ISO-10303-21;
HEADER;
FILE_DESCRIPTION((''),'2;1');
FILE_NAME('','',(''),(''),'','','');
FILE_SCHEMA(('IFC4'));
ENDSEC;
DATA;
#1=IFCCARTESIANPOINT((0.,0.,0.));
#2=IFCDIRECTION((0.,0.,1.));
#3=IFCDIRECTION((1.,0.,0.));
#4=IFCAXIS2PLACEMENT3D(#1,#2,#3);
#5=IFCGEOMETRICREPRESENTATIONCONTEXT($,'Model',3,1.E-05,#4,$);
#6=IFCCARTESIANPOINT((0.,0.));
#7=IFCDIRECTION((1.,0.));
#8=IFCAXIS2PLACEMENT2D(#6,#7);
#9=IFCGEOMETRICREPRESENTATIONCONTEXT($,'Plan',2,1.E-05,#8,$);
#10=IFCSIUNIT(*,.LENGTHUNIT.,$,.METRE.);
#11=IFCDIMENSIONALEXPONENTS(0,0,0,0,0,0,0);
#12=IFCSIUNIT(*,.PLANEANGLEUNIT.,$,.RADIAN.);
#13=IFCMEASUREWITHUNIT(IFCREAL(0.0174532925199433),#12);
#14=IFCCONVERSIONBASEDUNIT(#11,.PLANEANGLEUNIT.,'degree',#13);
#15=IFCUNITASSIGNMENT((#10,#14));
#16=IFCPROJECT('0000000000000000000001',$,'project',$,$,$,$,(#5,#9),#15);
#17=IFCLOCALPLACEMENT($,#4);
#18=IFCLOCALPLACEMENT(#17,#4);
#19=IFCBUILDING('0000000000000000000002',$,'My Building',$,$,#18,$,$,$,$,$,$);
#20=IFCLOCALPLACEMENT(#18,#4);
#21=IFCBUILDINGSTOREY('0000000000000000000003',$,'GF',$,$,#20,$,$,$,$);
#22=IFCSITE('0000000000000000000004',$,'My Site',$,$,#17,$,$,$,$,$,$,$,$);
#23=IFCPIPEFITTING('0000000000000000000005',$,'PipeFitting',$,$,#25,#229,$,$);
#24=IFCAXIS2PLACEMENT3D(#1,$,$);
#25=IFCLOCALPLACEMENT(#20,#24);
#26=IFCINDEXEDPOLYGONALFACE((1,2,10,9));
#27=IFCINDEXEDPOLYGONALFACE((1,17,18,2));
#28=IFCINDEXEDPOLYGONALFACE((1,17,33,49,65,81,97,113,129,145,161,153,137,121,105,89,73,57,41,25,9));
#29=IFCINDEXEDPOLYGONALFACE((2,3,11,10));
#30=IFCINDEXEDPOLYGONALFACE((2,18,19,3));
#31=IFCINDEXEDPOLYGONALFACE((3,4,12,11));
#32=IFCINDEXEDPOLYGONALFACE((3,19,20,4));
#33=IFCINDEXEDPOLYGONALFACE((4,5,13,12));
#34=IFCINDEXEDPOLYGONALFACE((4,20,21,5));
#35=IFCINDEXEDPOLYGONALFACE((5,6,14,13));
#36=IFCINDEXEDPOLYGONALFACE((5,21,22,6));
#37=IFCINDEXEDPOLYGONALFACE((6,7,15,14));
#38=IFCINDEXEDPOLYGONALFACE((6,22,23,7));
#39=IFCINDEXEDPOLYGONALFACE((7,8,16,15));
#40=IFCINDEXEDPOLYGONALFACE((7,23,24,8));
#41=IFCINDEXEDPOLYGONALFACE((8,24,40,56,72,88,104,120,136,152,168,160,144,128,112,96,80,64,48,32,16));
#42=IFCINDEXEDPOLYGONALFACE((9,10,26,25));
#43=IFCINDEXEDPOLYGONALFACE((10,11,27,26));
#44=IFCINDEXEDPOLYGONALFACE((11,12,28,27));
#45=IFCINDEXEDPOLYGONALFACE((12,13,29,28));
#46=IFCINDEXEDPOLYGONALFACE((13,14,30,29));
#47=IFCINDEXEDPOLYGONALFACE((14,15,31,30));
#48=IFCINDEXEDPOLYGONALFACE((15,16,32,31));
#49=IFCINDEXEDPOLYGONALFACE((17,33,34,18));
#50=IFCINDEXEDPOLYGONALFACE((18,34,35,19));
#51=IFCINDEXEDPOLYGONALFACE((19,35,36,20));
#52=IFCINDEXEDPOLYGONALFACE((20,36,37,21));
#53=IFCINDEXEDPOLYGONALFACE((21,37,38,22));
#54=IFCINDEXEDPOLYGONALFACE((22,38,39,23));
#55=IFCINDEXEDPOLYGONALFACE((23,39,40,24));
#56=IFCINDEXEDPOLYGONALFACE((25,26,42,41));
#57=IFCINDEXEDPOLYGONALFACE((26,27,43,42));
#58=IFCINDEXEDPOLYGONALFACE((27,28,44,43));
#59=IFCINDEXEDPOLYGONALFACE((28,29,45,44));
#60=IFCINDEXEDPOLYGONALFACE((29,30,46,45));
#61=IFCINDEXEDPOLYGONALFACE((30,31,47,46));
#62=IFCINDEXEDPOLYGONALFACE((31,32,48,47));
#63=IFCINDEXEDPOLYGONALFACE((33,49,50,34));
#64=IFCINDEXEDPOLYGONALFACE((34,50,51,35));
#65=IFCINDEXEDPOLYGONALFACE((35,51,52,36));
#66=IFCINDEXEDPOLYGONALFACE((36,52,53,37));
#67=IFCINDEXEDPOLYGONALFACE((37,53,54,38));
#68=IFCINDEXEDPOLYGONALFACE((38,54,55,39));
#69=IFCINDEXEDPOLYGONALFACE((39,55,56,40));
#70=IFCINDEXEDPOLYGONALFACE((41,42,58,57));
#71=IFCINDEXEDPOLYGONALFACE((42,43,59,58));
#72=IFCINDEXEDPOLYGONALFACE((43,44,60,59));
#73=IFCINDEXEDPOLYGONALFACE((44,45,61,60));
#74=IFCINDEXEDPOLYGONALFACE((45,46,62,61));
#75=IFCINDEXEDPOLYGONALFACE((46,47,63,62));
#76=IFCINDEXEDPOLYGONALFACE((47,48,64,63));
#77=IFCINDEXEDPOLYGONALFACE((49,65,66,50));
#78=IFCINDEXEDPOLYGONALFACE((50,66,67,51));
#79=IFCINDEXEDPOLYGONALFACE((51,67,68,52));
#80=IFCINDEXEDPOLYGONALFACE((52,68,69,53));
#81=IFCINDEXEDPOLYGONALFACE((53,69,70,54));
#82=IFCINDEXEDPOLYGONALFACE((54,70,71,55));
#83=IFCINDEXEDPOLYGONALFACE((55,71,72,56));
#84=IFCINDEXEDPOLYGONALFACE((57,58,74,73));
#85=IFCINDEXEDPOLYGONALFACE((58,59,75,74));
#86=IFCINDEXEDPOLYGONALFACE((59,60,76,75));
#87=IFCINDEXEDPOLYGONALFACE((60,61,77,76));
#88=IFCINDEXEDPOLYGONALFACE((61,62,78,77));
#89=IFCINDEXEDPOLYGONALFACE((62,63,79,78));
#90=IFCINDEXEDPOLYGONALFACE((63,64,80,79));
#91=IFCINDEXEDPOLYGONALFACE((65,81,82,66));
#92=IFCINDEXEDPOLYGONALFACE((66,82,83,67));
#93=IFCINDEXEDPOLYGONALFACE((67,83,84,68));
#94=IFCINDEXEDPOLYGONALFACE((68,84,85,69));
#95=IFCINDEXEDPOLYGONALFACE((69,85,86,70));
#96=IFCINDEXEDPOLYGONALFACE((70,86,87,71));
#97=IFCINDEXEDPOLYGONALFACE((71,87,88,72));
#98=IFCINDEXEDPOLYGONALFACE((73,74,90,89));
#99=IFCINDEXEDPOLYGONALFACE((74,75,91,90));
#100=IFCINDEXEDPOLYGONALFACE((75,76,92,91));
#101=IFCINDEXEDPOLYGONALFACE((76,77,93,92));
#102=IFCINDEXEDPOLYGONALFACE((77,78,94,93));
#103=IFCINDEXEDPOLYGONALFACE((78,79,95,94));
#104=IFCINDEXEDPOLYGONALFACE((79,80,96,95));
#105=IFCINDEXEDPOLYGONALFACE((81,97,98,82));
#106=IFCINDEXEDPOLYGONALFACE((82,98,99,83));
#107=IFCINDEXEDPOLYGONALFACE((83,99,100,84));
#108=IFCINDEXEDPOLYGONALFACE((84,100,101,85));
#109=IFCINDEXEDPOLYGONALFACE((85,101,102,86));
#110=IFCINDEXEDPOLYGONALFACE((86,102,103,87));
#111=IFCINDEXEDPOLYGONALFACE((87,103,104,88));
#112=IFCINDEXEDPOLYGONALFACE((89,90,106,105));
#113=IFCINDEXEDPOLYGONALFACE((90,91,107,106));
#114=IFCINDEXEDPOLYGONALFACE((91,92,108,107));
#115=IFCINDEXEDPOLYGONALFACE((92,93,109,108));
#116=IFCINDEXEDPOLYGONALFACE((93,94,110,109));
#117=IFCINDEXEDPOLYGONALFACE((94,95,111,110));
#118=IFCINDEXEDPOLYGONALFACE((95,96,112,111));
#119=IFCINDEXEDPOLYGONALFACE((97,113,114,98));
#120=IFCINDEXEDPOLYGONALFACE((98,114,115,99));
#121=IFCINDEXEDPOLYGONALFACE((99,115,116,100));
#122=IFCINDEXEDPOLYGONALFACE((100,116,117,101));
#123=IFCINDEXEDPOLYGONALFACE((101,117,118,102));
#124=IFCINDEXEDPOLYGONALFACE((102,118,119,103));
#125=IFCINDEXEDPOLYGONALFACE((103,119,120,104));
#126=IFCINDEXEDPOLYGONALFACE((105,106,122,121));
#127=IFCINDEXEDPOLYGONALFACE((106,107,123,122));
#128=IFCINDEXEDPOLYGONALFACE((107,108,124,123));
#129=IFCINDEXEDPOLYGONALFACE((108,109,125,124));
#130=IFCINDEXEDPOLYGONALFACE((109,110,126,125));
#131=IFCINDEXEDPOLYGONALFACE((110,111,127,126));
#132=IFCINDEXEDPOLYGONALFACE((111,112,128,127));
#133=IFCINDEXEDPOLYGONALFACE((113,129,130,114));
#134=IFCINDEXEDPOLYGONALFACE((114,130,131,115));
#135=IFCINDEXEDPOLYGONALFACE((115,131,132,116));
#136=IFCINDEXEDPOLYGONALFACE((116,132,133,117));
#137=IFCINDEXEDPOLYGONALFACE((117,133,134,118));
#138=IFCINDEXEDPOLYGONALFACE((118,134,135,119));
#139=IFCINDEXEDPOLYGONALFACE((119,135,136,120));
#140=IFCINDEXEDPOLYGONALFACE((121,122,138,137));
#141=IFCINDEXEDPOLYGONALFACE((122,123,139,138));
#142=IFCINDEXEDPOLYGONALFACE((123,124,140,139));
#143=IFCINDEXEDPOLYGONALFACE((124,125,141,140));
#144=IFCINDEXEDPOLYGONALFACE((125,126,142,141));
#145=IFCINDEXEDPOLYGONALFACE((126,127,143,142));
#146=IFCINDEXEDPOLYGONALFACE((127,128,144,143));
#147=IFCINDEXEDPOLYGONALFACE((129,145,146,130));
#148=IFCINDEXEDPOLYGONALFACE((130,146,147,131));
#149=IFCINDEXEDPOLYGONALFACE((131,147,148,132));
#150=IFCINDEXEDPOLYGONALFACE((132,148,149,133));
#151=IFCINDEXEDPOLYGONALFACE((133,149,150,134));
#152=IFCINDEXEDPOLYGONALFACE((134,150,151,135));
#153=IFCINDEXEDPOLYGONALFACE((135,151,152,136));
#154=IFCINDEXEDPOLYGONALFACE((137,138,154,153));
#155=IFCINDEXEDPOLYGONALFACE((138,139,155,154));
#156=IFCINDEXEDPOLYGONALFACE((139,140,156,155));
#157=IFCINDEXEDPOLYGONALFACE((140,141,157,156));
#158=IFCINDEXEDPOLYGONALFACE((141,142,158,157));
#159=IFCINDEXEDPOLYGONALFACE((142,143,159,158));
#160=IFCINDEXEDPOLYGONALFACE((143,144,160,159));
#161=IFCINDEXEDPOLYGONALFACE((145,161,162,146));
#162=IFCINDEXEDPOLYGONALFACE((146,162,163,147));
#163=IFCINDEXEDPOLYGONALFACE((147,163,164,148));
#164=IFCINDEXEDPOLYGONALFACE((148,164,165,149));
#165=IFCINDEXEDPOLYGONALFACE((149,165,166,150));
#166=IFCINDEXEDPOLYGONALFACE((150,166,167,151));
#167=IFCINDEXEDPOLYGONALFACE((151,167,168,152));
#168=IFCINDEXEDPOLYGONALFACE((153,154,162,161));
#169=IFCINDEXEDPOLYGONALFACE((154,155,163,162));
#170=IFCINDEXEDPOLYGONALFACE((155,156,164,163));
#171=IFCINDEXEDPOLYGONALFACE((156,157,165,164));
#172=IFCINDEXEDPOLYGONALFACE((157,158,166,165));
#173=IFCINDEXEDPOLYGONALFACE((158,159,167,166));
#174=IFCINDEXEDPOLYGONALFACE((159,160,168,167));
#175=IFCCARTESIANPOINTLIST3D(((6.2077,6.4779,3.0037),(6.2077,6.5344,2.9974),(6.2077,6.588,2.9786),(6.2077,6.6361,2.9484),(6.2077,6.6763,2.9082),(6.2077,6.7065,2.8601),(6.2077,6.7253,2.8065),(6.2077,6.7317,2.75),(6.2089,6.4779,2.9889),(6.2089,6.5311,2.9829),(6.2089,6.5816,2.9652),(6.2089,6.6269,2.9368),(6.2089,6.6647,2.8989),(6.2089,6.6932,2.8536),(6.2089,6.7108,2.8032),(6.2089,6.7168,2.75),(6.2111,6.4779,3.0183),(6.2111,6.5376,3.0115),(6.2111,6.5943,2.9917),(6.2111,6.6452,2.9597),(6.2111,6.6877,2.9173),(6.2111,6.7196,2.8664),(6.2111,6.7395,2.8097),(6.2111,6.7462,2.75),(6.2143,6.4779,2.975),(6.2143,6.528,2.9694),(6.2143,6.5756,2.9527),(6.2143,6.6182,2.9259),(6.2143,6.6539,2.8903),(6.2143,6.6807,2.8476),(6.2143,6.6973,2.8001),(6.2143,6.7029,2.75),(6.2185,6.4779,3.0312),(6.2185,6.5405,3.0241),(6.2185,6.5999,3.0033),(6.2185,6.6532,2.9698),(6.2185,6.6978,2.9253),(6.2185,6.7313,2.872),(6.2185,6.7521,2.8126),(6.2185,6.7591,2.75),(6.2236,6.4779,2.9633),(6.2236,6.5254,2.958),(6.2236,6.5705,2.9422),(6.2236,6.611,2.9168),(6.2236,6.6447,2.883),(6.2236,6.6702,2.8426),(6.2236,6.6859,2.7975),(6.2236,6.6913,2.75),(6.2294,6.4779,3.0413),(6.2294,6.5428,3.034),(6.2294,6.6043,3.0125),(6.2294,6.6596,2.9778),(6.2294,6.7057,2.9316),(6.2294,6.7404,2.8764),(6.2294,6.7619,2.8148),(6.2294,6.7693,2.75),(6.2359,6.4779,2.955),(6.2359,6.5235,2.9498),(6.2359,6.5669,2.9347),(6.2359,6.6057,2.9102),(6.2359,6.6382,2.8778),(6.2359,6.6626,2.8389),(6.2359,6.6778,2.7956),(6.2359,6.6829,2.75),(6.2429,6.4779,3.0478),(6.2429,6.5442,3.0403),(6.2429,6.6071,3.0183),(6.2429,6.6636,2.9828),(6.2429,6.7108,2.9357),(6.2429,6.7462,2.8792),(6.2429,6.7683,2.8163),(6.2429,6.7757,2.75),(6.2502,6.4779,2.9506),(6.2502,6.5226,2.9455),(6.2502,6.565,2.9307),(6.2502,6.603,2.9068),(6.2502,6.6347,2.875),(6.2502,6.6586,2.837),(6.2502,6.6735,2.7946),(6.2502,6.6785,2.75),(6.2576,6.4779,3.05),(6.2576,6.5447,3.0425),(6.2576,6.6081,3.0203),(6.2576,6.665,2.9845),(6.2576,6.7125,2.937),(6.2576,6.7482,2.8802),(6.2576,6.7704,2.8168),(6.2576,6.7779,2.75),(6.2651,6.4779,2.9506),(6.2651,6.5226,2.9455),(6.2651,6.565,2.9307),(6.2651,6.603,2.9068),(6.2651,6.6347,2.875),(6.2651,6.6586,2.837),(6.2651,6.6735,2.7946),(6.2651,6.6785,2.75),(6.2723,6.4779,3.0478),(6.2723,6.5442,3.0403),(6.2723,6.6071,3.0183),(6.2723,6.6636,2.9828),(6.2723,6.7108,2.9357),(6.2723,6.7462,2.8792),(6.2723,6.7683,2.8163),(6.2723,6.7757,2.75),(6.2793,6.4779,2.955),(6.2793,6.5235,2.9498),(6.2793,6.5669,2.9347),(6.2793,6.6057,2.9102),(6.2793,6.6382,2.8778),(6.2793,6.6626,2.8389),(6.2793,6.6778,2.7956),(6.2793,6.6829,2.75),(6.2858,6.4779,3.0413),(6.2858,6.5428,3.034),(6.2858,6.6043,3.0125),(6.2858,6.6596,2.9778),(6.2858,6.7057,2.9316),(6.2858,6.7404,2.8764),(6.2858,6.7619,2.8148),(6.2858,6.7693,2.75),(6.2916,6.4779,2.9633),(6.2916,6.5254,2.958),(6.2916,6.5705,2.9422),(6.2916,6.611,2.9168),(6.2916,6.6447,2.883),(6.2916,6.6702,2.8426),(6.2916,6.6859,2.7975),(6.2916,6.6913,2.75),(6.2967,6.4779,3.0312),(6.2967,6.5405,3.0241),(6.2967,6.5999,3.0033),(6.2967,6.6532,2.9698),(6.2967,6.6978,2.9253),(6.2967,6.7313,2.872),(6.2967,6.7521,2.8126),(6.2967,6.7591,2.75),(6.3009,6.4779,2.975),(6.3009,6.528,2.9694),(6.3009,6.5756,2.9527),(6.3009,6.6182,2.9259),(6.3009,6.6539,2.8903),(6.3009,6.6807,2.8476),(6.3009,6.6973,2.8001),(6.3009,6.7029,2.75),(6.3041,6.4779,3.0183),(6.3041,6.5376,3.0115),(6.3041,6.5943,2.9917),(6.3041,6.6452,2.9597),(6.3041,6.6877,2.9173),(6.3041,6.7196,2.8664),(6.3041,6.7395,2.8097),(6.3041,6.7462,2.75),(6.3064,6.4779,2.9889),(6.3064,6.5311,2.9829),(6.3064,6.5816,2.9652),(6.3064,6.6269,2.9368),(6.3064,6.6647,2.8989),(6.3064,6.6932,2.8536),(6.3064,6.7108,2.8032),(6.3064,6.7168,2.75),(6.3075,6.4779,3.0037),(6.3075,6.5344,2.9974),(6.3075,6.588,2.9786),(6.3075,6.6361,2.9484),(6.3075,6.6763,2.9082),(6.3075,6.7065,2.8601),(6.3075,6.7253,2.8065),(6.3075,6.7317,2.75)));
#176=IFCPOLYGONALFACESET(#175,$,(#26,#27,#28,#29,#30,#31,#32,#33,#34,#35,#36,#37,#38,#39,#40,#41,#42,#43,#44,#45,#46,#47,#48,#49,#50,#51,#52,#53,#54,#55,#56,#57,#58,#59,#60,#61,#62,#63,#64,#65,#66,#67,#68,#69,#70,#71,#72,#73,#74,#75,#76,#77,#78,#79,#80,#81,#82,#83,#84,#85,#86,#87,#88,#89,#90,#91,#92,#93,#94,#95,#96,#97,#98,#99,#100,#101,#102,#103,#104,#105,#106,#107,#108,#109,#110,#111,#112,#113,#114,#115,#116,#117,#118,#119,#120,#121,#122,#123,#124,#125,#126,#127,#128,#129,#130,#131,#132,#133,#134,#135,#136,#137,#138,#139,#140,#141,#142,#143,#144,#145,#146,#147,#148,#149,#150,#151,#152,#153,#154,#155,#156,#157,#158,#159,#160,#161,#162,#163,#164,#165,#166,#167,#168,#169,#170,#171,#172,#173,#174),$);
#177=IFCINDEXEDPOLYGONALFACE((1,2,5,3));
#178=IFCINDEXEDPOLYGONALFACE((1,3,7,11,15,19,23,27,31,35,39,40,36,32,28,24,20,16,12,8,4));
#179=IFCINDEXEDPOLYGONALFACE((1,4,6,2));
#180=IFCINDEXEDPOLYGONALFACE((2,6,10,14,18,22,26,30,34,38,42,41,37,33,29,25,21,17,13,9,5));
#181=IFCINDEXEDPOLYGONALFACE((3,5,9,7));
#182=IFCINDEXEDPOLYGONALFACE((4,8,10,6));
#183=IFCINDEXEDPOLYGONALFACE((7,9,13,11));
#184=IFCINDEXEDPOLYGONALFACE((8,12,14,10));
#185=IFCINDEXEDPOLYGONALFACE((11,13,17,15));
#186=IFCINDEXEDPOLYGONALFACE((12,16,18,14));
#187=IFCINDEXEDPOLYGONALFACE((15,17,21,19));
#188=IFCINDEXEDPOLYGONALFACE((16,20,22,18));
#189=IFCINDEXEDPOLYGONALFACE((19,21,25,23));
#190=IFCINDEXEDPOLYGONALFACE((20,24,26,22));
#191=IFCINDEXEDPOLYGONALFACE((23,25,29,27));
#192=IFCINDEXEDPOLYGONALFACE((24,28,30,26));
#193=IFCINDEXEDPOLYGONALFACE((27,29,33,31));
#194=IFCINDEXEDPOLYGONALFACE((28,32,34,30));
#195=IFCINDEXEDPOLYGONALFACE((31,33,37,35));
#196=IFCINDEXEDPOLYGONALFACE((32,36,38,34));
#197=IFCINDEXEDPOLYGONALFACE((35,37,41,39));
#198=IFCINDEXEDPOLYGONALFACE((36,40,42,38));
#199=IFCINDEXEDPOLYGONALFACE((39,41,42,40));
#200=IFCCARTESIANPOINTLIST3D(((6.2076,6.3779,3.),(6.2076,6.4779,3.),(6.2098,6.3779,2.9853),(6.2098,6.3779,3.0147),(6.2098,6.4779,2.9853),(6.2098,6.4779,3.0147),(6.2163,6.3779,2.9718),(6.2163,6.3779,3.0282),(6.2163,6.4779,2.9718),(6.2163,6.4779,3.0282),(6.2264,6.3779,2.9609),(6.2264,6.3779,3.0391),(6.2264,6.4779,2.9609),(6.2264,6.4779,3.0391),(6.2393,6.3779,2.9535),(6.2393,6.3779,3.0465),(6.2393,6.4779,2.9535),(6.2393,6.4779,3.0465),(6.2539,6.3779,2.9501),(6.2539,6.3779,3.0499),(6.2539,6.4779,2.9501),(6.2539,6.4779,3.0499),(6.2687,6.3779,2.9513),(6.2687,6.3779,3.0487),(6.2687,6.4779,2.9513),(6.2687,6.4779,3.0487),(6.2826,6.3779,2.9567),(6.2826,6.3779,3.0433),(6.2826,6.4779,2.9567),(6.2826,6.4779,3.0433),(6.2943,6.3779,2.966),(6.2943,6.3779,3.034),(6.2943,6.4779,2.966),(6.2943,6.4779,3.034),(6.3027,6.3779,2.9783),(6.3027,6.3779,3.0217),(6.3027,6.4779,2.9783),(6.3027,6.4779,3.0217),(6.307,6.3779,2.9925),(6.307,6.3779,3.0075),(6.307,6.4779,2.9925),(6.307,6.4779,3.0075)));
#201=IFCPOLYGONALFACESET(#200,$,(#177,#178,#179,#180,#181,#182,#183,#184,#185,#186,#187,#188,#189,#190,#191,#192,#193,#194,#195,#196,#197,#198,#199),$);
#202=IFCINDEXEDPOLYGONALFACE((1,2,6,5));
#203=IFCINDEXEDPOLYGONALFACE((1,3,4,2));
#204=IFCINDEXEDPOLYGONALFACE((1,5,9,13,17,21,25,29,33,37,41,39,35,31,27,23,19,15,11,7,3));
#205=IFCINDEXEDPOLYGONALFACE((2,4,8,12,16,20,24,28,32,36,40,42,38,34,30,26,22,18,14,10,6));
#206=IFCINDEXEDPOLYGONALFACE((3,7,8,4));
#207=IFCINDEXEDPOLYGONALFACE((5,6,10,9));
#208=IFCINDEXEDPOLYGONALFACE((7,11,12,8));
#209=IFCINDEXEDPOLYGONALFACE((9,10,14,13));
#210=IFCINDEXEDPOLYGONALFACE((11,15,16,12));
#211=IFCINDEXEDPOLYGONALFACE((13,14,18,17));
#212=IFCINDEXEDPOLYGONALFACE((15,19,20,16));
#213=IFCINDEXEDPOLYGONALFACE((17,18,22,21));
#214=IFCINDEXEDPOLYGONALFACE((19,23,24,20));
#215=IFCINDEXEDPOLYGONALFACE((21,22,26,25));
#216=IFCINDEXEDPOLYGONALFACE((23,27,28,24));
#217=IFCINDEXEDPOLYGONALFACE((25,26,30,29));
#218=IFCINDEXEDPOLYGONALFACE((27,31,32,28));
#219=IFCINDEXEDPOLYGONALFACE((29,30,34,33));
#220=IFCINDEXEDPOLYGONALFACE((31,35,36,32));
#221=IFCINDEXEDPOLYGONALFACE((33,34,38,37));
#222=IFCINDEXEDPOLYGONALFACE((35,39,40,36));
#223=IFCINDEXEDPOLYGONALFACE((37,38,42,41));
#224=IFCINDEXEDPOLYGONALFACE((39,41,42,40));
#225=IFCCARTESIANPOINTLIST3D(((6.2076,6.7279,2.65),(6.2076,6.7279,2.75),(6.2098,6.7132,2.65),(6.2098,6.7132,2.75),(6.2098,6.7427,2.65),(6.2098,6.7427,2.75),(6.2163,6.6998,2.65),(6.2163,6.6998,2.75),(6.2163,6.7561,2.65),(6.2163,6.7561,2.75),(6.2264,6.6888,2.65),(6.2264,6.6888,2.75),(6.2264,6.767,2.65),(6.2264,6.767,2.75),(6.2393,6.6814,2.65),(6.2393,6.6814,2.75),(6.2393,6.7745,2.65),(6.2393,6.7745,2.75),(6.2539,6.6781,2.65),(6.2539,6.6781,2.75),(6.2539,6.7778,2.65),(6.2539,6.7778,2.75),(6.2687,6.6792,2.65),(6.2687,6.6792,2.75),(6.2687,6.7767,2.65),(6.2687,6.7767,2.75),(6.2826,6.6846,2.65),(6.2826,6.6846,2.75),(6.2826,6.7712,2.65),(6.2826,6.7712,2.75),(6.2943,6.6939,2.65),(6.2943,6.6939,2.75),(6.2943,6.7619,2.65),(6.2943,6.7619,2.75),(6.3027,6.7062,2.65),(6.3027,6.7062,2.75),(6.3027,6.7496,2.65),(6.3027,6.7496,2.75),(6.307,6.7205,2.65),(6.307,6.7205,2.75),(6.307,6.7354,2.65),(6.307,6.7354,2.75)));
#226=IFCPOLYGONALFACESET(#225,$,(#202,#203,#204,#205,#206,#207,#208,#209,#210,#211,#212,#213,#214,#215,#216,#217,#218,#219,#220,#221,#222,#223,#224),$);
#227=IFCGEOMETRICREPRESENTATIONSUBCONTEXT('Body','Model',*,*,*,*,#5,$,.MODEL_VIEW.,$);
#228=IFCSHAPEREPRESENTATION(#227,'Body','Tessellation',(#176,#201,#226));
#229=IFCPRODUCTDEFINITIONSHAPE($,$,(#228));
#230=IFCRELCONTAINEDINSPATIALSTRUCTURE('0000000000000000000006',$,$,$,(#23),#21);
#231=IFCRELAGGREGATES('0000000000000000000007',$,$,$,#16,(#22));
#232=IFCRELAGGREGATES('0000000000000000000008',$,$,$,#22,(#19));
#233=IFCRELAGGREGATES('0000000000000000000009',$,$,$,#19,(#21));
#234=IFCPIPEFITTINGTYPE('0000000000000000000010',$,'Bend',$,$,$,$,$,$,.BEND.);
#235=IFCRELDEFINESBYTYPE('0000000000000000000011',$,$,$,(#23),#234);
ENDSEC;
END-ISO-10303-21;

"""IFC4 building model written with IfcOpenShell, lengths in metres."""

from ifc_helpers import new_model, entity, si_unit, converted_unit, frame, origin_with_axes, origin_2d_with_axis, place, context, subcontext, project, spatial, circle, extrude, source, transform, mapped, type_object, type_shapes, element, save


model = new_model("IFC4")

# Units and contexts
model_context = context("Model", 3, precision=1e-05, world=origin_with_axes())
plan_context = context("Plan", 2, precision=1e-05, world=origin_2d_with_axis())
body_context_1 = subcontext(model_context, "Body", "Model", "MODEL_VIEW")
ifc_project = project(units=[si_unit("LENGTHUNIT", "METRE"), converted_unit("PLANEANGLEUNIT", "degree", entity("IfcReal", 0.0174532925199433), si_unit("PLANEANGLEUNIT", "RADIAN"), dimensions=[0, 0, 0, 0, 0, 0, 0])], contexts=[model_context, plan_context])

# Site, building, storey
site_placement = place(None, origin_with_axes())
site = spatial("IfcSite", under=ifc_project, at=site_placement, Name="My Site")
building_placement = place(site_placement, origin_with_axes())
building = spatial("IfcBuilding", under=site, at=building_placement, Name="My Building")
storey_placement = place(building_placement, origin_with_axes())
storey = spatial("IfcBuildingStorey", under=building, at=storey_placement, Name="GF")

# Pipe fitting
pipe_fitting_type = type_object("IfcPipeFittingType", Name="Bend", PredefinedType="BEND")
shared_shape_1 = source(origin_with_axes(), body_context_1, "Body", "SolidModel", [
    entity("IfcSweptDiskSolid", entity("IfcIndexedPolyCurve", entity("IfcCartesianPointList3D", [[0.0, 0.0, 0.1], [0.0, -0.0732, 0.2768], [0.0, -0.25, 0.35]]), [entity("IfcArcIndex", [1, 2, 3])]), 0.05),
    extrude(circle(Radius=0.05), origin_with_axes(), (0.0, 0.0, 1.0), 0.1),
    extrude(circle(Radius=0.05), frame((0.0, -0.25, 0.35), z_axis=(0.0, -1.0, 0.0), x_axis=(1.0, 0.0, 0.0)), (0.0, 0.0, 1.0), 0.1),
])
type_shapes(pipe_fitting_type, [shared_shape_1])
for number, where, z_axis, x_axis, name in (
    (1, (6.2576, 6.3779, 3.0), (0.0, 1.0, 0.0), (-1.0, 0.0, 0.0), "PipeFitting"),
):
    element("IfcPipeFitting", number, at=place(storey_placement, frame(where, z_axis=z_axis, x_axis=x_axis)), inside=storey, type_object=pipe_fitting_type, Name=name, context=body_context_1, shape_type="MappedRepresentation", body=[
        mapped(shared_shape_1, transform((0.0, 0.0, 0.0), x_axis=(1.0, 0.0, 0.0), y_axis=(0.0, 1.0, 0.0), z_axis=(0.0, 0.0, 1.0), scale=1.0)),
    ])

save(model, "model.ifc")
